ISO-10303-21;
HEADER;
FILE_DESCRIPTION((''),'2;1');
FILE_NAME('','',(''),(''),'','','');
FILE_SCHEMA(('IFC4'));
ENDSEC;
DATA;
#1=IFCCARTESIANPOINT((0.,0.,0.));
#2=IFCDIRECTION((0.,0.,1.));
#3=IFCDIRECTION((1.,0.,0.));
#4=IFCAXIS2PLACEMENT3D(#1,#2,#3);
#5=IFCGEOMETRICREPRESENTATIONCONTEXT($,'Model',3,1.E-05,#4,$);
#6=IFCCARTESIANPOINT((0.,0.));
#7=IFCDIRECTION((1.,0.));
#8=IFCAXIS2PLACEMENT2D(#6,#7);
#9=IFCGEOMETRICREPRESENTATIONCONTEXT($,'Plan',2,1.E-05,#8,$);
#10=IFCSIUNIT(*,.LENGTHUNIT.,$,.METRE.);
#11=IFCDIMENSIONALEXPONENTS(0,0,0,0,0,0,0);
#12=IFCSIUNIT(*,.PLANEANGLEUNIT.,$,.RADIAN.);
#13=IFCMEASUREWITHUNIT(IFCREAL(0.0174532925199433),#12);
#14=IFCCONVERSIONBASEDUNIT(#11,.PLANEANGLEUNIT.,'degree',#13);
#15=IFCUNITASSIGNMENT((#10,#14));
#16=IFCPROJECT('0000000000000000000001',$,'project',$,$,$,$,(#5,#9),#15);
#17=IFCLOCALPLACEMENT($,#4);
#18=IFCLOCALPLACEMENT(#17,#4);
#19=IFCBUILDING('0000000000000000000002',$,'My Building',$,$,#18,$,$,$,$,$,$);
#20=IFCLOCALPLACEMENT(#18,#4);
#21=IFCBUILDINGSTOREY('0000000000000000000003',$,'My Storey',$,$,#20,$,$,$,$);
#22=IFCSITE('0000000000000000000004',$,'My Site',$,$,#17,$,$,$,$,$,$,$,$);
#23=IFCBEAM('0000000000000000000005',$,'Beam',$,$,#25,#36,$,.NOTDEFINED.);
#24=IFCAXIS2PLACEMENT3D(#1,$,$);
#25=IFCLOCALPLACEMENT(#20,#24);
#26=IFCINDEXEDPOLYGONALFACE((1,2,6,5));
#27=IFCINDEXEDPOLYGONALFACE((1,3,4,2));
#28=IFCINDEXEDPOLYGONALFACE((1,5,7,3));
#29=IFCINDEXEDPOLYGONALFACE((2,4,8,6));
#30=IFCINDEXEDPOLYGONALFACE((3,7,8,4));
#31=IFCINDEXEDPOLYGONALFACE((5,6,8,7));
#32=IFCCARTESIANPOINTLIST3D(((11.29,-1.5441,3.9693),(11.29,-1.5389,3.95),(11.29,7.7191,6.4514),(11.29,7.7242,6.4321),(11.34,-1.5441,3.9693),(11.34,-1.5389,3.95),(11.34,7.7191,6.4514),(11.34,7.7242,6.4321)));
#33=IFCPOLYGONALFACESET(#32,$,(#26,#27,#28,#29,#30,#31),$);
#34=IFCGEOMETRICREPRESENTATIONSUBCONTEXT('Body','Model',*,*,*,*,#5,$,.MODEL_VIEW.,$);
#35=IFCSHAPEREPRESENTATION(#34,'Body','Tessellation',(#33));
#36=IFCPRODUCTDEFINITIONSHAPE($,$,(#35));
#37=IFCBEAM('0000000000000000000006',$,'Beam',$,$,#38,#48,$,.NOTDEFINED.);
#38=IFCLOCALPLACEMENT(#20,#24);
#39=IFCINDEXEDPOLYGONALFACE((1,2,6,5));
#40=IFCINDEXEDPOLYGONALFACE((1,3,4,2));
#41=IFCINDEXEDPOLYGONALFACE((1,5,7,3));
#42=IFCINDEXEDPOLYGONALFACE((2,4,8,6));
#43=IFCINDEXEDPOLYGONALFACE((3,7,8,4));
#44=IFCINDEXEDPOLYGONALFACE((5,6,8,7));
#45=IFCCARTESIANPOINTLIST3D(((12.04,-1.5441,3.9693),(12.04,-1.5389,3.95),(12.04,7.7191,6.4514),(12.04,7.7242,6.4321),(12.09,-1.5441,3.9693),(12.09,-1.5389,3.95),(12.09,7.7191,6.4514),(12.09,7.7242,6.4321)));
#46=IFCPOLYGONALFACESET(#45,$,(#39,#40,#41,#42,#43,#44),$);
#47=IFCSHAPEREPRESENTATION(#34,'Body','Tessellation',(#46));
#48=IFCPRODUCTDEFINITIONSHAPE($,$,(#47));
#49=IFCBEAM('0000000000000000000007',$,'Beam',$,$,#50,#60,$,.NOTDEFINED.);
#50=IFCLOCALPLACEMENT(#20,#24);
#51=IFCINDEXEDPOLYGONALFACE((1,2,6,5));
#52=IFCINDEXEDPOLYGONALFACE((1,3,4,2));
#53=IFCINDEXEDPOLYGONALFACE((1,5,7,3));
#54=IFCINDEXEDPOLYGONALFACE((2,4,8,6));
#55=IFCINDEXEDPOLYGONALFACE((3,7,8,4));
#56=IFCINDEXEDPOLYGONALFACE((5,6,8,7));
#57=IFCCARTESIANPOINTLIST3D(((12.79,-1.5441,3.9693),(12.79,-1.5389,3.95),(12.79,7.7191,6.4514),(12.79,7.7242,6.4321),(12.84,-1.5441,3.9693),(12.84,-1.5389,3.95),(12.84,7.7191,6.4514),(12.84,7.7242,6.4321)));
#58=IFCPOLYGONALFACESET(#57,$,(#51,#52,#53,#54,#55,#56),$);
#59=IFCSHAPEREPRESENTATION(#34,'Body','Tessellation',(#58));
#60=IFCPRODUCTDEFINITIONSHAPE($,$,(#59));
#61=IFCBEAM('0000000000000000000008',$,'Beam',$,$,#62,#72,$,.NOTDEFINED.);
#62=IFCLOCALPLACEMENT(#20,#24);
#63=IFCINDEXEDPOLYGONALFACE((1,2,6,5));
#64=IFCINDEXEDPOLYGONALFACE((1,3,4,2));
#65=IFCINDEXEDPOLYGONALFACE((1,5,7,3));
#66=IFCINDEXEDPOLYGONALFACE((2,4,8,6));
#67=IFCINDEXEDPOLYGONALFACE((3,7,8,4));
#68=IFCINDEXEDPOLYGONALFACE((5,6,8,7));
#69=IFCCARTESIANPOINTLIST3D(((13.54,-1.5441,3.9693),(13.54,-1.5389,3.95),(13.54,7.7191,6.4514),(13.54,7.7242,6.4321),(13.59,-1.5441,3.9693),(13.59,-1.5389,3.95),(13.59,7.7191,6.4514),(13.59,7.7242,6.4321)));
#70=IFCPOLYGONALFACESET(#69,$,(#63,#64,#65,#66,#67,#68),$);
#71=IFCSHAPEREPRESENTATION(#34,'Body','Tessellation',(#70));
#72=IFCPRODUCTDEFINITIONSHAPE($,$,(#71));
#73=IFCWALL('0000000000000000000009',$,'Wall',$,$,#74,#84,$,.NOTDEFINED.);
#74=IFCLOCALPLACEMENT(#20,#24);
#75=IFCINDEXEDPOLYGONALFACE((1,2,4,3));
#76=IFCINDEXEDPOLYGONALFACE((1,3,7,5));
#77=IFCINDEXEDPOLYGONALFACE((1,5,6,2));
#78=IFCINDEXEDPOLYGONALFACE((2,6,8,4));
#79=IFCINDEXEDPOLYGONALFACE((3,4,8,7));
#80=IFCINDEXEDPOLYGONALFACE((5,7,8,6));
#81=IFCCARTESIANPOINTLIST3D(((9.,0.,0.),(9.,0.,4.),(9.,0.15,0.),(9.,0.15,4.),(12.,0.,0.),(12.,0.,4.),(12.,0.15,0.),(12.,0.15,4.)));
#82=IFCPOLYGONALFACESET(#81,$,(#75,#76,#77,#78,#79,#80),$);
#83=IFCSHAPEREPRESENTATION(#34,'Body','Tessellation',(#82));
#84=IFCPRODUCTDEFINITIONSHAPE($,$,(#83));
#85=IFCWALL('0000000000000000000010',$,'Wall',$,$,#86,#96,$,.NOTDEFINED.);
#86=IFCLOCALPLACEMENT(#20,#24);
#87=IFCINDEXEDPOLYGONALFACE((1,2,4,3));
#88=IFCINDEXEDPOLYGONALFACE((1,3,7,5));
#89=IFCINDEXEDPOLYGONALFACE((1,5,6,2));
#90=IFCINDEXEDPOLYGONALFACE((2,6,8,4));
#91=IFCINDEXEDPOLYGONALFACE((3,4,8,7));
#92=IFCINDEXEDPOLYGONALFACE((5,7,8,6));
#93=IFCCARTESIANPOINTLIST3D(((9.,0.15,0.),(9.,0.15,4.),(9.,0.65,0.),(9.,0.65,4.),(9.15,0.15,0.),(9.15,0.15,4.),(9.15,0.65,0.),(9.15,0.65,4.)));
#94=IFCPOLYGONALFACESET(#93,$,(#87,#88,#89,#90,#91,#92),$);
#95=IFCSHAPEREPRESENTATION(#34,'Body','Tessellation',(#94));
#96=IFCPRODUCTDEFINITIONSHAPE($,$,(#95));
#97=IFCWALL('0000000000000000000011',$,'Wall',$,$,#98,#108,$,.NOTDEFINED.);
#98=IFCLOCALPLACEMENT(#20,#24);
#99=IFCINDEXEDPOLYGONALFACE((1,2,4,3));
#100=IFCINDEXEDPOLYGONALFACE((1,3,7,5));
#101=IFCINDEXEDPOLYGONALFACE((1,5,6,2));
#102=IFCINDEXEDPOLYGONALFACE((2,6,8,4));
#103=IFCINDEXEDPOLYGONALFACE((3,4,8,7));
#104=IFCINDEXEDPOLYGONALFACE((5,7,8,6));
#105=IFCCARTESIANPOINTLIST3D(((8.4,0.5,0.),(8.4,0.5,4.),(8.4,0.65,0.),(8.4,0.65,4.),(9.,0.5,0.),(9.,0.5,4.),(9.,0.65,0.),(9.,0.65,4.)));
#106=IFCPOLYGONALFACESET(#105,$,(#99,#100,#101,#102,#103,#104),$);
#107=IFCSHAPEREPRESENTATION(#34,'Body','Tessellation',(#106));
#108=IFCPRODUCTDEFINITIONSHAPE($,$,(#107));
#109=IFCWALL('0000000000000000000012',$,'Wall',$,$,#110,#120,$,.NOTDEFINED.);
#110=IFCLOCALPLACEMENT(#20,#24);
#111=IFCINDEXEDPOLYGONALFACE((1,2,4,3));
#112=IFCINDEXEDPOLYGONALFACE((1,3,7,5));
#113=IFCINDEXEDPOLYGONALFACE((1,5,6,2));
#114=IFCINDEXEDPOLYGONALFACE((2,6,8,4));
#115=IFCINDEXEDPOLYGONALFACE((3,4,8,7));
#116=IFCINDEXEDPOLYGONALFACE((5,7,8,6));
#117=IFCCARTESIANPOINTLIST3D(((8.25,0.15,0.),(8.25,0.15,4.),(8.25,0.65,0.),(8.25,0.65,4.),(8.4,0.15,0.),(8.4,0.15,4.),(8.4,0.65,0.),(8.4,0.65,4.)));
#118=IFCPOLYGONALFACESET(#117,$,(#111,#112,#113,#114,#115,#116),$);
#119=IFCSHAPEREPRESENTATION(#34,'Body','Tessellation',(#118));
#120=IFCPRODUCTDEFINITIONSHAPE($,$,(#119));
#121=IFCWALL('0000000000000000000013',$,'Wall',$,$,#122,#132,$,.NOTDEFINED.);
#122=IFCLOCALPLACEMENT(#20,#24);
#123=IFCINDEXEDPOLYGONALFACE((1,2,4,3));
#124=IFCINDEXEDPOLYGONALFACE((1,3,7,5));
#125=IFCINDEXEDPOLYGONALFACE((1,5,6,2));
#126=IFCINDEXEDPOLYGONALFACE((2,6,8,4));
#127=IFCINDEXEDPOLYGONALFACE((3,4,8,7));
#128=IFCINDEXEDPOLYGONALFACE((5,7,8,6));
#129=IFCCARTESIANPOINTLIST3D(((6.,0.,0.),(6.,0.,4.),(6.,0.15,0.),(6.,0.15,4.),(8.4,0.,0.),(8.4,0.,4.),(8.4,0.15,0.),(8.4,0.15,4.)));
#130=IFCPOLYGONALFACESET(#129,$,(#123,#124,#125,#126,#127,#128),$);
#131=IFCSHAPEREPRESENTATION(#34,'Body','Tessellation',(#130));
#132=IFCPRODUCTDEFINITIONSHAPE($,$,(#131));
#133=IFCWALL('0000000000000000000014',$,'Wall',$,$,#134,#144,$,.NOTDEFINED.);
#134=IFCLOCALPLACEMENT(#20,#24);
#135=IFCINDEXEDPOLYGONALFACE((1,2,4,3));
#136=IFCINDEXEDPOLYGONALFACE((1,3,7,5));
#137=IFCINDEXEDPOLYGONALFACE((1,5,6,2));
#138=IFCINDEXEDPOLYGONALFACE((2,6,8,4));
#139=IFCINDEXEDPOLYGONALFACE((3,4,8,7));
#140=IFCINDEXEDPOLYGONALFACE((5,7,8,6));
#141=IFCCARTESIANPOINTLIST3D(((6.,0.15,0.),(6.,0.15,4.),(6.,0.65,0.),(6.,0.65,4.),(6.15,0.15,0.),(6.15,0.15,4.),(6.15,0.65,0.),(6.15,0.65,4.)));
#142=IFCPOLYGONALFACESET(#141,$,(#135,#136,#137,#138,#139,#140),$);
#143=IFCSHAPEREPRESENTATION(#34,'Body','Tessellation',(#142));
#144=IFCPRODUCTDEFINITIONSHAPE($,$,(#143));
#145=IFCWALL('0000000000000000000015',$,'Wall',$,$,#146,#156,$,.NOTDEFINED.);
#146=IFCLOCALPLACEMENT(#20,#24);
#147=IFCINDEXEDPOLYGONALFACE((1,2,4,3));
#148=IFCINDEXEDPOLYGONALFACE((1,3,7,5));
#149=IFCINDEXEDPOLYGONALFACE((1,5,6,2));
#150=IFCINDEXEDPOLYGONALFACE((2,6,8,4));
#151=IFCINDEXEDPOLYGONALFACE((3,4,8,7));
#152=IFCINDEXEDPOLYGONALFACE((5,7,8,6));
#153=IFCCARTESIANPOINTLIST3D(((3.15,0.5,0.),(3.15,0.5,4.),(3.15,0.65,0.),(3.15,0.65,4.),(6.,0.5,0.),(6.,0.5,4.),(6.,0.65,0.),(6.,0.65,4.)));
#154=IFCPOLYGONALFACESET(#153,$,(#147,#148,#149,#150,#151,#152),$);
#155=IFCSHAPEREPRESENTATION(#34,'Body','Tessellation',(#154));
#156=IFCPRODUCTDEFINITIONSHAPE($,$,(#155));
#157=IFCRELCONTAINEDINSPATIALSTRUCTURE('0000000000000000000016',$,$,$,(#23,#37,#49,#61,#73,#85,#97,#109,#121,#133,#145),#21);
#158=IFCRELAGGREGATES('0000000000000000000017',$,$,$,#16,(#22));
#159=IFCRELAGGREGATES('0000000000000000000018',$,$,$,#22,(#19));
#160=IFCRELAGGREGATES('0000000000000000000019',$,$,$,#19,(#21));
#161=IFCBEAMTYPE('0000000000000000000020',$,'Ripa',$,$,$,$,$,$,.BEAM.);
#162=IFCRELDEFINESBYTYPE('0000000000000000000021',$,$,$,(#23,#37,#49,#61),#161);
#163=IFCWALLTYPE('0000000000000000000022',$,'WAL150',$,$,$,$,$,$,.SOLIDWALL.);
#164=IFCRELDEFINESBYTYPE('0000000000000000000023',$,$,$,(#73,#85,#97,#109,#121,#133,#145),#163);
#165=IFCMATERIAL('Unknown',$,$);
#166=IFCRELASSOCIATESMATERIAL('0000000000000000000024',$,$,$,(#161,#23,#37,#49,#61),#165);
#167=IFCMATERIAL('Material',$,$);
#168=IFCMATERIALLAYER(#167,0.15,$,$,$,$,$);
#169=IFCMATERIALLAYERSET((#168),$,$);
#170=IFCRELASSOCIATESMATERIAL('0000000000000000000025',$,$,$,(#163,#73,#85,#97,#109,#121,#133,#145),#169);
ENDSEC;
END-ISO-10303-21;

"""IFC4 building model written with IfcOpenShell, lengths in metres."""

from ifc_helpers import new_model, entity, si_unit, converted_unit, frame, origin_with_axes, origin_2d_with_axis, place, context, subcontext, project, spatial, indexed_curve, rectangle, outline, extrude, material, layer, layer_set, layer_usage, material_profile, profile_set, profile_usage, type_object, element, save


model = new_model("IFC4")

# Units and contexts
model_context = context("Model", 3, precision=1e-05, world=origin_with_axes())
plan_context = context("Plan", 2, precision=1e-05, world=origin_2d_with_axis())
body_context = subcontext(model_context, "Body", "Model", "MODEL_VIEW")
ifc_project = project(units=[si_unit("LENGTHUNIT", "METRE"), converted_unit("PLANEANGLEUNIT", "degree", entity("IfcReal", 0.0174532925199433), si_unit("PLANEANGLEUNIT", "RADIAN"), dimensions=[0, 0, 0, 0, 0, 0, 0])], contexts=[model_context, plan_context])

# Site, building, storey
site_placement = place(None, origin_with_axes())
site = spatial("IfcSite", under=ifc_project, at=site_placement, Name="My Site")
building_placement = place(site_placement, origin_with_axes())
building = spatial("IfcBuilding", under=site, at=building_placement, Name="My Building")
storey_placement = place(building_placement, origin_with_axes())
storey = spatial("IfcBuildingStorey", under=building, at=storey_placement, Name="My Storey")

# Shared definitions
ifc_material_1 = material(Name="Unknown")

# Beams
ifc_material_profile_1 = material_profile(ifc_material_1, rectangle(XDim=0.05, YDim=0.02))
ifc_profile_set_1 = profile_set([ifc_material_profile_1])
beam_type_1 = type_object("IfcBeamType", Name="Ripa", PredefinedType="BEAM", material=ifc_profile_set_1)
ifc_profile_usage_1 = profile_usage(ifc_profile_set_1, cardinal=2)
beam_1_placement = place(storey_placement, frame((11.315, -1.5389, 3.95), z_axis=(-0.000001, 0.965926, 0.25882), x_axis=(-1.0, -0.000001, 0.0)))
element("IfcBeam", 1, at=beam_1_placement, inside=storey, type_object=beam_type_1, material=ifc_profile_usage_1, Name="Beam", PredefinedType="NOTDEFINED", context=body_context, shape_type="SweptSolid", body=[
    extrude(rectangle(XDim=0.05, YDim=0.02), frame((0.0, 0.01, 0.0), z_axis=(0.0, 0.0, 1.0), x_axis=(1.0, 0.0, 0.0)), (0.0, 0.0, 1.0), 9.5899),
])
ifc_profile_usage_2 = profile_usage(ifc_profile_set_1, cardinal=2)
beam_2_placement = place(storey_placement, frame((12.065, -1.5389, 3.95), z_axis=(-0.000001, 0.965926, 0.25882), x_axis=(-1.0, -0.000001, 0.0)))
element("IfcBeam", 2, at=beam_2_placement, inside=storey, type_object=beam_type_1, material=ifc_profile_usage_2, Name="Beam", PredefinedType="NOTDEFINED", context=body_context, shape_type="SweptSolid", body=[
    extrude(rectangle(XDim=0.05, YDim=0.02), frame((0.0, 0.01, 0.0), z_axis=(0.0, 0.0, 1.0), x_axis=(1.0, 0.0, 0.0)), (0.0, 0.0, 1.0), 9.5899),
])
ifc_profile_usage_3 = profile_usage(ifc_profile_set_1, cardinal=2)
beam_3_placement = place(storey_placement, frame((12.815, -1.5389, 3.95), z_axis=(-0.000001, 0.965926, 0.25882), x_axis=(-1.0, -0.000001, 0.0)))
element("IfcBeam", 3, at=beam_3_placement, inside=storey, type_object=beam_type_1, material=ifc_profile_usage_3, Name="Beam", PredefinedType="NOTDEFINED", context=body_context, shape_type="SweptSolid", body=[
    extrude(rectangle(XDim=0.05, YDim=0.02), frame((0.0, 0.01, 0.0), z_axis=(0.0, 0.0, 1.0), x_axis=(1.0, 0.0, 0.0)), (0.0, 0.0, 1.0), 9.5899),
])
ifc_profile_usage_4 = profile_usage(ifc_profile_set_1, cardinal=2)
beam_4_placement = place(storey_placement, frame((13.565, -1.5389, 3.95), z_axis=(-0.000001, 0.965926, 0.25882), x_axis=(-1.0, -0.000001, 0.0)))
element("IfcBeam", 4, at=beam_4_placement, inside=storey, type_object=beam_type_1, material=ifc_profile_usage_4, Name="Beam", PredefinedType="NOTDEFINED", context=body_context, shape_type="SweptSolid", body=[
    extrude(rectangle(XDim=0.05, YDim=0.02), frame((0.0, 0.01, 0.0), z_axis=(0.0, 0.0, 1.0), x_axis=(1.0, 0.0, 0.0)), (0.0, 0.0, 1.0), 9.5899),
])

# Walls
ifc_material_2 = material(Name="Material")
ifc_layer = layer(ifc_material_2, 0.15)
ifc_layer_set = layer_set([ifc_layer])
ifc_layer_usage_1 = layer_usage(ifc_layer_set, "AXIS2", "POSITIVE", 0.0)
wall_type = type_object("IfcWallType", Name="WAL150", PredefinedType="SOLIDWALL", material=ifc_layer_set)
wall_1_placement = place(storey_placement, frame((9.0, 0.0, 0.0), z_axis=(0.0, 0.0, 1.0), x_axis=(1.0, 0.0, 0.0)))
element("IfcWall", 5, at=wall_1_placement, inside=storey, type_object=wall_type, material=ifc_layer_usage_1, Name="Wall", PredefinedType="NOTDEFINED", context=body_context, shape_type="SweptSolid", body=[
    extrude(outline(indexed_curve([(0.0, 0.0), (0.0, 0.15), (3.0, 0.15), (3.0, 0.0), (0.0, 0.0)], self_intersect=False)), origin_with_axes(), (0.0, 0.0, 1.0), 4.0),
])
ifc_layer_usage_2 = layer_usage(ifc_layer_set, "AXIS2", "POSITIVE", 0.0)
wall_2_placement = place(storey_placement, frame((9.0, 0.65, 0.0), z_axis=(0.0, 0.0, 1.0), x_axis=(-0.000001, -1.0, 0.0)))
element("IfcWall", 6, at=wall_2_placement, inside=storey, type_object=wall_type, material=ifc_layer_usage_2, Name="Wall", PredefinedType="NOTDEFINED", context=body_context, shape_type="SweptSolid", body=[
    extrude(outline(indexed_curve([(0.0, 0.0), (0.0, 0.15), (0.5, 0.15), (0.5, 0.0), (0.0, 0.0)], self_intersect=False)), origin_with_axes(), (0.0, 0.0, 1.0), 4.0),
])
ifc_layer_usage_3 = layer_usage(ifc_layer_set, "AXIS2", "POSITIVE", 0.0)
wall_3_placement = place(storey_placement, frame((9.0, 0.65, 0.0), z_axis=(0.0, 0.0, 1.0), x_axis=(-1.0, 0.000001, 0.0)))
element("IfcWall", 7, at=wall_3_placement, inside=storey, type_object=wall_type, material=ifc_layer_usage_3, Name="Wall", PredefinedType="NOTDEFINED", context=body_context, shape_type="SweptSolid", body=[
    extrude(outline(indexed_curve([(0.0, 0.0), (0.0, 0.15), (0.6, 0.15), (0.6, 0.0), (0.0, 0.0)], self_intersect=False)), origin_with_axes(), (0.0, 0.0, 1.0), 4.0),
])
ifc_layer_usage_4 = layer_usage(ifc_layer_set, "AXIS2", "POSITIVE", 0.0)
wall_4_placement = place(storey_placement, frame((8.25, 0.65, 0.0), z_axis=(0.0, 0.0, 1.0), x_axis=(-0.000001, -1.0, 0.0)))
element("IfcWall", 8, at=wall_4_placement, inside=storey, type_object=wall_type, material=ifc_layer_usage_4, Name="Wall", PredefinedType="NOTDEFINED", context=body_context, shape_type="SweptSolid", body=[
    extrude(outline(indexed_curve([(0.0, 0.0), (0.0, 0.15), (0.5, 0.15), (0.5, 0.0), (0.0, 0.0)], self_intersect=False)), origin_with_axes(), (0.0, 0.0, 1.0), 4.0),
])
ifc_layer_usage_5 = layer_usage(ifc_layer_set, "AXIS2", "POSITIVE", 0.0)
wall_5_placement = place(storey_placement, frame((6.0, 0.0, 0.0), z_axis=(0.0, 0.0, 1.0), x_axis=(1.0, -0.000001, 0.0)))
element("IfcWall", 9, at=wall_5_placement, inside=storey, type_object=wall_type, material=ifc_layer_usage_5, Name="Wall", PredefinedType="NOTDEFINED", context=body_context, shape_type="SweptSolid", body=[
    extrude(outline(indexed_curve([(0.0, 0.0), (0.0, 0.15), (2.4, 0.15), (2.4, 0.0), (0.0, 0.0)], self_intersect=False)), origin_with_axes(), (0.0, 0.0, 1.0), 4.0),
])
ifc_layer_usage_6 = layer_usage(ifc_layer_set, "AXIS2", "POSITIVE", 0.0)
wall_6_placement = place(storey_placement, frame((6.0, 0.65, 0.0), z_axis=(0.0, 0.0, 1.0), x_axis=(-0.000001, -1.0, 0.0)))
element("IfcWall", 10, at=wall_6_placement, inside=storey, type_object=wall_type, material=ifc_layer_usage_6, Name="Wall", PredefinedType="NOTDEFINED", context=body_context, shape_type="SweptSolid", body=[
    extrude(outline(indexed_curve([(0.0, 0.0), (0.0, 0.15), (0.5, 0.15), (0.5, 0.0), (0.0, 0.0)], self_intersect=False)), origin_with_axes(), (0.0, 0.0, 1.0), 4.0),
])
ifc_layer_usage_7 = layer_usage(ifc_layer_set, "AXIS2", "POSITIVE", 0.0)
wall_7_placement = place(storey_placement, frame((6.0, 0.65, 0.0), z_axis=(0.0, 0.0, 1.0), x_axis=(-1.0, 0.0, 0.0)))
element("IfcWall", 11, at=wall_7_placement, inside=storey, type_object=wall_type, material=ifc_layer_usage_7, Name="Wall", PredefinedType="NOTDEFINED", context=body_context, shape_type="SweptSolid", body=[
    extrude(outline(indexed_curve([(0.0, 0.0), (0.0, 0.15), (2.85, 0.15), (2.85, 0.0), (0.0, 0.0)], self_intersect=False)), origin_with_axes(), (0.0, 0.0, 1.0), 4.0),
])

save(model, "model.ifc")
